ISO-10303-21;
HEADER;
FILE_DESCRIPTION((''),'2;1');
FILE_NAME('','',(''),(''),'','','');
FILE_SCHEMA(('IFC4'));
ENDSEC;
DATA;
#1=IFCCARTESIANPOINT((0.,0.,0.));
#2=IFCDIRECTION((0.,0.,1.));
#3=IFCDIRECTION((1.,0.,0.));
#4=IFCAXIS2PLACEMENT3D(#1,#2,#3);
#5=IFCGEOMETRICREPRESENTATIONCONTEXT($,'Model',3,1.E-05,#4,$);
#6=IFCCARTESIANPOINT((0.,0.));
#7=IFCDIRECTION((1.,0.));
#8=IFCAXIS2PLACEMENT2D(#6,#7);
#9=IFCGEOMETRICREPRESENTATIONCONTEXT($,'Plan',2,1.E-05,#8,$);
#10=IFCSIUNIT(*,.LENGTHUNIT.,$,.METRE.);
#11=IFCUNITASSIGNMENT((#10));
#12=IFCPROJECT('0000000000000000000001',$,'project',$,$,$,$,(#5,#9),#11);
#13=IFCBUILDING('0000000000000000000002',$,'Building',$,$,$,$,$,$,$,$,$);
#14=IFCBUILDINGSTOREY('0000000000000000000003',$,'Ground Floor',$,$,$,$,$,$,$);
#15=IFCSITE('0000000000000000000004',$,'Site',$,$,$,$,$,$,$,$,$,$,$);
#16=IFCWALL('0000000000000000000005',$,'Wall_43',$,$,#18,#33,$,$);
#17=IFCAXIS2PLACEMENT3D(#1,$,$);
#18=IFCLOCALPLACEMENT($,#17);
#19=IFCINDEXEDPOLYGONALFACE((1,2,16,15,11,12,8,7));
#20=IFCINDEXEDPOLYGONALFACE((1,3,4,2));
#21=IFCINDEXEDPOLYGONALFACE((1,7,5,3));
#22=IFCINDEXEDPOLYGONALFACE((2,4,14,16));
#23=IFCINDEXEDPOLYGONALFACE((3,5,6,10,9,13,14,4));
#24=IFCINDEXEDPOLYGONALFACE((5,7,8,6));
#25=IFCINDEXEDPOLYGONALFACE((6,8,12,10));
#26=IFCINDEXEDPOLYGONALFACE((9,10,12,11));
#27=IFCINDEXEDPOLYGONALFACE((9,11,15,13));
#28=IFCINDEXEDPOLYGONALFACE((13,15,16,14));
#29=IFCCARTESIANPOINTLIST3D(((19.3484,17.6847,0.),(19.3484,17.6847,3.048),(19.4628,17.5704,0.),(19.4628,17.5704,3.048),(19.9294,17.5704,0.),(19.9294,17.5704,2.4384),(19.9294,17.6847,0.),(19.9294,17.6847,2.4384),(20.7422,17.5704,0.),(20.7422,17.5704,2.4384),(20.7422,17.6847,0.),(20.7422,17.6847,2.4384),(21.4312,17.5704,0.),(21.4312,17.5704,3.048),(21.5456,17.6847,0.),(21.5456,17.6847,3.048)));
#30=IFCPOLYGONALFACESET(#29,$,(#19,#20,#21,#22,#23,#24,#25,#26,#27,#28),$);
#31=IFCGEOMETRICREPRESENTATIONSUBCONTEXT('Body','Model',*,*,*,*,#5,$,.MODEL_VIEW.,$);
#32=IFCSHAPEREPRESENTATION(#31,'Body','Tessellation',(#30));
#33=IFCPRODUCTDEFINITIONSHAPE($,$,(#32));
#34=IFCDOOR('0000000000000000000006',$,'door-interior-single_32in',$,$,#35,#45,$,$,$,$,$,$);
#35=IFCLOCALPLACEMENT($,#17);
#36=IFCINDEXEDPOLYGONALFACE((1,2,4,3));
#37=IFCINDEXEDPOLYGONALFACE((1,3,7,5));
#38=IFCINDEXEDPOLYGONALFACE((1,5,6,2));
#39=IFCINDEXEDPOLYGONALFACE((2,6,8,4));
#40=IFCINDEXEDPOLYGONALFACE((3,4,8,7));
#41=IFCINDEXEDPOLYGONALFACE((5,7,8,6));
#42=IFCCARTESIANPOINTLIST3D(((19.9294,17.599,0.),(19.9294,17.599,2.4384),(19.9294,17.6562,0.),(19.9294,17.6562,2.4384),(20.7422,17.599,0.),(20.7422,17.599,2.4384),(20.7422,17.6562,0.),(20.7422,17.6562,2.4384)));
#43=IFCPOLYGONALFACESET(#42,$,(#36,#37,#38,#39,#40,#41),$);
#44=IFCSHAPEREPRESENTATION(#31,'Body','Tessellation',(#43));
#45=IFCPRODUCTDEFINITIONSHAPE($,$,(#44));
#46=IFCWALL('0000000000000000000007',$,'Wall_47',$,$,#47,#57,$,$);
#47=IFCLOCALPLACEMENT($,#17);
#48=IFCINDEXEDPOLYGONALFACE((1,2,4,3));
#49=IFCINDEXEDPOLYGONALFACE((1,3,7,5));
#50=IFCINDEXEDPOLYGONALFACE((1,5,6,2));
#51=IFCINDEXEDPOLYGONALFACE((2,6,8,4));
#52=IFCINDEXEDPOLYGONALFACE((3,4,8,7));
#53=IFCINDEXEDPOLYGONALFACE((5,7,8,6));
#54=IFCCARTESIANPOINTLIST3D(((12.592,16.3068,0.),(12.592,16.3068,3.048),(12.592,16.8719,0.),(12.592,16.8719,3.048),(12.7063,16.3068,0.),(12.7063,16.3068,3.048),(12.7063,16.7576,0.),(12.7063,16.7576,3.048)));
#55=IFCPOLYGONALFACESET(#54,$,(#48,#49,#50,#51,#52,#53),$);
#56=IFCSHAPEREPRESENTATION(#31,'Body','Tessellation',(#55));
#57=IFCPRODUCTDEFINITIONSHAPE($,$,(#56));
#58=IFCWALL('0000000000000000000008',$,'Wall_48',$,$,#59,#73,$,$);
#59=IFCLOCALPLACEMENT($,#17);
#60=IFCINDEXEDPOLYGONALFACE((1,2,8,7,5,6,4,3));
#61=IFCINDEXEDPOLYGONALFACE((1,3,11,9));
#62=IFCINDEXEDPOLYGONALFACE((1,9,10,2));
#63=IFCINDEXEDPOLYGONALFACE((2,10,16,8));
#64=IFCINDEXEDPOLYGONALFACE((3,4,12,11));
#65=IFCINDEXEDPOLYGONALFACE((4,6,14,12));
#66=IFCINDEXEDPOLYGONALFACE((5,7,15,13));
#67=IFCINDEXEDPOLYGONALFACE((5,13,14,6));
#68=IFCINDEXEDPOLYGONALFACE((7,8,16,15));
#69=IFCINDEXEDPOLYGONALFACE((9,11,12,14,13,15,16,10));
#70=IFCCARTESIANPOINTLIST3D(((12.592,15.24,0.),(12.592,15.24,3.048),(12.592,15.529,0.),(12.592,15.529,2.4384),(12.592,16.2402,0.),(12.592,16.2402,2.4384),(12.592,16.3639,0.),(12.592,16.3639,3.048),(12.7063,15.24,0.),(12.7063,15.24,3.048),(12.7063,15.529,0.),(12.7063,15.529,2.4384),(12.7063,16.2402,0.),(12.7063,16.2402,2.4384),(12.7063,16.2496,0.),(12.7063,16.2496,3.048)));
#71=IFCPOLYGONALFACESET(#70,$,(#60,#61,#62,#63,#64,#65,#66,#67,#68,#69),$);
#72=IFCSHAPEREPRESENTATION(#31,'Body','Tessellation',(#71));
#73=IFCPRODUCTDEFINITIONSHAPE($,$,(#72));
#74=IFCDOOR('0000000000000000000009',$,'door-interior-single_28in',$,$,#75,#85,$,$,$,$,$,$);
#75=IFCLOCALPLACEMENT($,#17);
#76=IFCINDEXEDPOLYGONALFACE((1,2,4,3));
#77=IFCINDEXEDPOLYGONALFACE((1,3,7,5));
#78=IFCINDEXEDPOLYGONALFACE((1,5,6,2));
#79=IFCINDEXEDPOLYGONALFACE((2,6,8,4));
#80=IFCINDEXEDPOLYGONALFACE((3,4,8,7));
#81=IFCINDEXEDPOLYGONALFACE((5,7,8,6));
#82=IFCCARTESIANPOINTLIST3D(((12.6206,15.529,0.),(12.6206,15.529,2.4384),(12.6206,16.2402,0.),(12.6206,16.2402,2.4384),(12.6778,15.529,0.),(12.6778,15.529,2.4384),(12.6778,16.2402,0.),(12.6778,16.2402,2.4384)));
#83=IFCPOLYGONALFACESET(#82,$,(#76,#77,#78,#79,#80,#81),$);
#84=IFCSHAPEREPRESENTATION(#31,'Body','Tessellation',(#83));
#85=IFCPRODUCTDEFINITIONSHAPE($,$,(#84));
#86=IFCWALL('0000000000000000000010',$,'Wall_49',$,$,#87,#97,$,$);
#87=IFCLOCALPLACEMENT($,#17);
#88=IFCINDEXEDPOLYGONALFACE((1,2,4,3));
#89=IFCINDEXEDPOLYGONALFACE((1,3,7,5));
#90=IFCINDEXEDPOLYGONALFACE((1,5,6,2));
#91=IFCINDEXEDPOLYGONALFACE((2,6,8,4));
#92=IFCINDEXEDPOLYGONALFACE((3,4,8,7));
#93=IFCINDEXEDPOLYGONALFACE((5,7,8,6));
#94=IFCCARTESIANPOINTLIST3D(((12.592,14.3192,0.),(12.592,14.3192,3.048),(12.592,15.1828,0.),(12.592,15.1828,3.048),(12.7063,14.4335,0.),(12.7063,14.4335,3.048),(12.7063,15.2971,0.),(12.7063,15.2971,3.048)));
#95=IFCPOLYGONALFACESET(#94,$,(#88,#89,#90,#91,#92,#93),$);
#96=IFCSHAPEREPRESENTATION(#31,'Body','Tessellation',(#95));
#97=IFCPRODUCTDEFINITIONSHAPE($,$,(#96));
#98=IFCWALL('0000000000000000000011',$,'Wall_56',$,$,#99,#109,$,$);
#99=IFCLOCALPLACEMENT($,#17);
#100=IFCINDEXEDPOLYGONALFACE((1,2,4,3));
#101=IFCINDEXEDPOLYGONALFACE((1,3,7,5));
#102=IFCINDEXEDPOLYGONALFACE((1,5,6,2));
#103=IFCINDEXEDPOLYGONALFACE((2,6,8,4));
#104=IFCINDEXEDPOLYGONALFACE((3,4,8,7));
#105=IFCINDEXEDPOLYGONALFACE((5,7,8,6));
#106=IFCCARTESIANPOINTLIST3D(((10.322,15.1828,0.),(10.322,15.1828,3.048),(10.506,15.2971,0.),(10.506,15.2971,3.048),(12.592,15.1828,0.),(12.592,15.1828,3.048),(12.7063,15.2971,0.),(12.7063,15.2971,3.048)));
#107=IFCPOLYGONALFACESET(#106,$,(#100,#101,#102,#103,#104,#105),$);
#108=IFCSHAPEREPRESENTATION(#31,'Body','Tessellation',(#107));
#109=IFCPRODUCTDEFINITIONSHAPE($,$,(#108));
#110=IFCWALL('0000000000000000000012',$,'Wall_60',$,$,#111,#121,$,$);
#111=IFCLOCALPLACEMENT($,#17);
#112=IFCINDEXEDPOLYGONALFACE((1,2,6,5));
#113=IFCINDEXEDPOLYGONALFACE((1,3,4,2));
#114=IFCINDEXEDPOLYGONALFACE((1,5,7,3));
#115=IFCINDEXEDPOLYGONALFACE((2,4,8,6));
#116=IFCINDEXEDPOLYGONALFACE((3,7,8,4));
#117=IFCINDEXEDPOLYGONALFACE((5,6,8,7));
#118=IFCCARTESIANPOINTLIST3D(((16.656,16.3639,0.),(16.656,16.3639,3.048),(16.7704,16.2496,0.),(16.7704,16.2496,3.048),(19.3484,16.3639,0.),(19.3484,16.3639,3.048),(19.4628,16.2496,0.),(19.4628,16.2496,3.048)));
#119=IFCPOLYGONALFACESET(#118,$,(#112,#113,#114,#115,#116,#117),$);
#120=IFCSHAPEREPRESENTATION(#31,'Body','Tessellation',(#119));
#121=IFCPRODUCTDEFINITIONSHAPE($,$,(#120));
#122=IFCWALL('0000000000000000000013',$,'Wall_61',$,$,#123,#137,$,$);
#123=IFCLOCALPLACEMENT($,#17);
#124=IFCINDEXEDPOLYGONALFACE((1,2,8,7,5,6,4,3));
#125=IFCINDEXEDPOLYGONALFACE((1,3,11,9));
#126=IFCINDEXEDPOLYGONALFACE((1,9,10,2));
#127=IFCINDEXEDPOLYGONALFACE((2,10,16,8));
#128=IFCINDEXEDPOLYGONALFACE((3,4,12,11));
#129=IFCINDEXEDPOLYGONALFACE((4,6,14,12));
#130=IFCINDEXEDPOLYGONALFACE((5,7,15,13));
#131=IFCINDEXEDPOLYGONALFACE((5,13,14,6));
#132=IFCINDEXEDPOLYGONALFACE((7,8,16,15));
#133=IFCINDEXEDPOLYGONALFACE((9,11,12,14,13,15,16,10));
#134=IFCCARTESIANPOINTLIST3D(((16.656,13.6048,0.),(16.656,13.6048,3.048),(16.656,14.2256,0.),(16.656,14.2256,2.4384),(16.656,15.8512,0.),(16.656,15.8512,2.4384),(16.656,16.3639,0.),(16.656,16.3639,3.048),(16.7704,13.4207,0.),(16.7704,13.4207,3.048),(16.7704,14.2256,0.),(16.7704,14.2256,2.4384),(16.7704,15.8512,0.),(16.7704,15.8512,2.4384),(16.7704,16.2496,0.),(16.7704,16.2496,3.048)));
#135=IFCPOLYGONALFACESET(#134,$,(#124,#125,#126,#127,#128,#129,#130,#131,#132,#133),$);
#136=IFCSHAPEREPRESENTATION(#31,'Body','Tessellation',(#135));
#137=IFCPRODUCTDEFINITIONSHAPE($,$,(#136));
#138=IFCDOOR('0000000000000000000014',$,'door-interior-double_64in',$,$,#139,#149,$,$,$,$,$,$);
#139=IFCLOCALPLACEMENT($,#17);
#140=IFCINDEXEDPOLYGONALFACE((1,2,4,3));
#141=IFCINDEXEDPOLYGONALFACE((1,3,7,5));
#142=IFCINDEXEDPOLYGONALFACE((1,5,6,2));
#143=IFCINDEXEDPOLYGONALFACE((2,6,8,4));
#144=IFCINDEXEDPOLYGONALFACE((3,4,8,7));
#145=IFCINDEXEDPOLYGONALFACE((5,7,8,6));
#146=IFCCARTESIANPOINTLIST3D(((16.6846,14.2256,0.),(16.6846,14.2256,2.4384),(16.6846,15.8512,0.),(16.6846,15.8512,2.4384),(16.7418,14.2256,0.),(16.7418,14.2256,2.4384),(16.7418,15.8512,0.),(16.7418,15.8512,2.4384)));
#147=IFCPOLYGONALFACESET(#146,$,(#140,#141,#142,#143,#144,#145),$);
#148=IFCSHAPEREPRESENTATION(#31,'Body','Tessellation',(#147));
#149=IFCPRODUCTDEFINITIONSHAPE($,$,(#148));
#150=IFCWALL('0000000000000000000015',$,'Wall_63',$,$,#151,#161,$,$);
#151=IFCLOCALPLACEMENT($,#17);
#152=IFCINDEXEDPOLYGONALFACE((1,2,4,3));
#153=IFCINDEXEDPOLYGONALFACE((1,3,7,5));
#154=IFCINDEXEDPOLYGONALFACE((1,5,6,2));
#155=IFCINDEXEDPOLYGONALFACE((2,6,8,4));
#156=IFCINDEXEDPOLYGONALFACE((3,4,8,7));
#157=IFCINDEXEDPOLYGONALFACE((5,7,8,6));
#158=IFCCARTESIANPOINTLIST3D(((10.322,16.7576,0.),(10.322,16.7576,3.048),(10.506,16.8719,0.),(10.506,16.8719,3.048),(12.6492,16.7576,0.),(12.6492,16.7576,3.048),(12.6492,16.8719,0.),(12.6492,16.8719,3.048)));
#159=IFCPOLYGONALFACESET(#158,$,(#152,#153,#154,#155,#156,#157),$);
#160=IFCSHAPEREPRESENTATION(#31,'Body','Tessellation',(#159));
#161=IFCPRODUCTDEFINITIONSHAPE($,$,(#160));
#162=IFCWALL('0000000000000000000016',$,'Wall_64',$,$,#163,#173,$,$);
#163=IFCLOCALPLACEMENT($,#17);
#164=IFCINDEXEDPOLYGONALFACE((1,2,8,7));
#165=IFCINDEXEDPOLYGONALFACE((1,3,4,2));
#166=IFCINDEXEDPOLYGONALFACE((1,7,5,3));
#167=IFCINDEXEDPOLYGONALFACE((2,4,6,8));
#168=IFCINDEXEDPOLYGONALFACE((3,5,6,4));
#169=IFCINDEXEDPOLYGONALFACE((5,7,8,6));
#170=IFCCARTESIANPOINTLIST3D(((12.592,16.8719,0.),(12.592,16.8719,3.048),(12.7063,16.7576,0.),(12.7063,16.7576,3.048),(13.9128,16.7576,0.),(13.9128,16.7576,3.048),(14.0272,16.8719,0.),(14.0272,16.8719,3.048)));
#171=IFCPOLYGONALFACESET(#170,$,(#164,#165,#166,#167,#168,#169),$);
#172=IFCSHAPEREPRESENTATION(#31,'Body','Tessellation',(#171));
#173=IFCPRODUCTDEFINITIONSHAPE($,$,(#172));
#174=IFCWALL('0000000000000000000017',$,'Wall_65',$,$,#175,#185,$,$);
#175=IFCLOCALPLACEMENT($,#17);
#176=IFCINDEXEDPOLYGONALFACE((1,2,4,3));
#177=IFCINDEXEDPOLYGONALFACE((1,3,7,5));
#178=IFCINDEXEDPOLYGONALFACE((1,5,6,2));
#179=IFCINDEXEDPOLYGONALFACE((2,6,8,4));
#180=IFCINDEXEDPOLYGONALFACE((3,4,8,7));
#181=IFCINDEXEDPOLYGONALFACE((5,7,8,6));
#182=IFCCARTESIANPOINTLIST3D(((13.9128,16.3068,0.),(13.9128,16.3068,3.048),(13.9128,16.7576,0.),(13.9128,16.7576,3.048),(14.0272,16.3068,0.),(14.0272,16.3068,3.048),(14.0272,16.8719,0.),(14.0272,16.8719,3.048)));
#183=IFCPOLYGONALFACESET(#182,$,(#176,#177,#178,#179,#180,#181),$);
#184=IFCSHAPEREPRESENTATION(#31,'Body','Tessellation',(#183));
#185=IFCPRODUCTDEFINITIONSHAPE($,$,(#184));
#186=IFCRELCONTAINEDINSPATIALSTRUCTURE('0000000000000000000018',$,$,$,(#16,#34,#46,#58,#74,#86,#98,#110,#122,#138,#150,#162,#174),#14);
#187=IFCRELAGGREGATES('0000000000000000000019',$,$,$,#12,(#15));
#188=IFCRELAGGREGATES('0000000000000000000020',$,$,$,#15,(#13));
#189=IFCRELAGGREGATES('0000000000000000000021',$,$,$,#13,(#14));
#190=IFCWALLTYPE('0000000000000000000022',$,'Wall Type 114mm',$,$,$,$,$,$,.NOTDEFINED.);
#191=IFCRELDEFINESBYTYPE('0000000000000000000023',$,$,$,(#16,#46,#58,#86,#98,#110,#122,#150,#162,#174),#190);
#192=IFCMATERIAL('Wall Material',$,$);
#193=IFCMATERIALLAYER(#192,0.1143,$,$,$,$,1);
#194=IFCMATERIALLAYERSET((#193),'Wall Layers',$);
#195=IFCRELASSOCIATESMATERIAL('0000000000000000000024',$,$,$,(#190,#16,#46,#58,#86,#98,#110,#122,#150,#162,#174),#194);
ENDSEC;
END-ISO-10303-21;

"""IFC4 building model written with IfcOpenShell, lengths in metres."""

from ifc_helpers import new_model, si_unit, frame, origin_with_axes, origin_2d_with_axis, place, context, subcontext, project, spatial, line, indexed_curve, rectangle, outline, extrude, material, layer, layer_set, layer_usage, type_object, element, fill, save


model = new_model("IFC4")

# Units and contexts
model_context = context("Model", 3, precision=1e-05, world=origin_with_axes())
plan_context = context("Plan", 2, precision=1e-05, world=origin_2d_with_axis())
body_context = subcontext(model_context, "Body", "Model", "MODEL_VIEW")
ifc_project = project(units=[si_unit("LENGTHUNIT", "METRE")], contexts=[model_context, plan_context])

# Site, building, storey
site = spatial("IfcSite", under=ifc_project, Name="Site")
building = spatial("IfcBuilding", under=site, Name="Building")
storey = spatial("IfcBuildingStorey", under=building, Name="Ground Floor")

# Shared definitions
ifc_material_1 = material(Name="Wall Material")
ifc_layer_1 = layer(ifc_material_1, 0.1143, Priority=1)
ifc_layer_set_1 = layer_set([ifc_layer_1], Name="Wall Layers")
wall_type_1 = type_object("IfcWallType", Name="Wall Type 114mm", PredefinedType="NOTDEFINED", material=ifc_layer_set_1)

# Wall, opening, door
ifc_layer_usage_1 = layer_usage(ifc_layer_set_1, "AXIS2", "POSITIVE", -0.0571)
wall_1_placement = place(None, frame((19.4056, 17.6276, 0.0), z_axis=(0.0, 0.0, 1.0), x_axis=(1.0, 0.0, 0.0)))
wall_1 = element("IfcWall", 1, at=wall_1_placement, inside=storey, type_object=wall_type_1, material=ifc_layer_usage_1, Name="Wall_43", context=body_context, shape_type="SweptSolid", body=[
    extrude(outline(indexed_curve([(0.0571, -0.0571), (-0.0571, 0.0571), (2.1399, 0.0571), (2.0256, -0.0571)], segments=[line(1, 2, 3, 4, 1)])), origin_with_axes(), (0.0, 0.0, 1.0), 3.048),
])
opening_1_placement = place(wall_1_placement, frame((0.9302, 0.0, 0.0), z_axis=(0.0, 0.0, 1.0), x_axis=(1.0, 0.0, 0.0)))
opening_1 = element("IfcOpeningElement", 2, at=opening_1_placement, cuts=wall_1, context=body_context, shape_type="SweptSolid", body=[
    extrude(rectangle(XDim=0.8128, YDim=0.5), None, (0.0, 0.0, 1.0), 2.4384),
])
door_1_placement = place(None, frame((20.3358, 17.6276, 0.0), z_axis=(0.0, 0.0, 1.0), x_axis=(-1.0, 0.0, 0.0)))
door_1 = element("IfcDoor", 3, at=door_1_placement, inside=storey, Name="door-interior-single_32in", context=body_context, shape_type="SweptSolid", body=[
    extrude(rectangle(XDim=0.8128, YDim=0.0571), None, (0.0, 0.0, 1.0), 2.4384),
])
fill(opening_1, door_1)

# Wall
ifc_layer_usage_2 = layer_usage(ifc_layer_set_1, "AXIS2", "POSITIVE", -0.0571)
wall_2_placement = place(None, frame((12.6492, 16.8148, 0.0), z_axis=(0.0, 0.0, 1.0), x_axis=(0.0, -1.0, 0.0)))
element("IfcWall", 4, at=wall_2_placement, inside=storey, type_object=wall_type_1, material=ifc_layer_usage_2, Name="Wall_47", context=body_context, shape_type="SweptSolid", body=[
    extrude(outline(indexed_curve([(-0.0572, -0.0571), (0.0572, 0.0571), (0.508, 0.0571), (0.508, -0.0571)], segments=[line(1, 2, 3, 4, 1)])), origin_with_axes(), (0.0, 0.0, 1.0), 3.048),
])

# Wall, opening, door
ifc_layer_usage_3 = layer_usage(ifc_layer_set_1, "AXIS2", "POSITIVE", -0.0571)
wall_3_placement = place(None, frame((12.6492, 16.3068, 0.0), z_axis=(0.0, 0.0, 1.0), x_axis=(0.0, -1.0, 0.0)))
wall_3 = element("IfcWall", 5, at=wall_3_placement, inside=storey, type_object=wall_type_1, material=ifc_layer_usage_3, Name="Wall_48", context=body_context, shape_type="SweptSolid", body=[
    extrude(outline(indexed_curve([(-0.0572, -0.0571), (0.0572, 0.0571), (1.0668, 0.0571), (1.0668, -0.0571)], segments=[line(1, 2, 3, 4, 1)])), origin_with_axes(), (0.0, 0.0, 1.0), 3.048),
])
opening_2_placement = place(wall_3_placement, frame((0.4222, 0.0, 0.0), z_axis=(0.0, 0.0, 1.0), x_axis=(1.0, 0.0, 0.0)))
opening_2 = element("IfcOpeningElement", 6, at=opening_2_placement, cuts=wall_3, context=body_context, shape_type="SweptSolid", body=[
    extrude(rectangle(XDim=0.7112, YDim=0.5), None, (0.0, 0.0, 1.0), 2.4384),
])
door_2_placement = place(None, frame((12.6492, 15.8846, 0.0), z_axis=(0.0, 0.0, 1.0), x_axis=(0.0, 1.0, 0.0)))
door_2 = element("IfcDoor", 7, at=door_2_placement, inside=storey, Name="door-interior-single_28in", context=body_context, shape_type="SweptSolid", body=[
    extrude(rectangle(XDim=0.7112, YDim=0.0571), None, (0.0, 0.0, 1.0), 2.4384),
])
fill(opening_2, door_2)

# Walls
ifc_layer_usage_4 = layer_usage(ifc_layer_set_1, "AXIS2", "POSITIVE", -0.0571)
wall_4_placement = place(None, frame((12.6492, 15.24, 0.0), z_axis=(0.0, 0.0, 1.0), x_axis=(0.0, -1.0, 0.0)))
element("IfcWall", 8, at=wall_4_placement, inside=storey, type_object=wall_type_1, material=ifc_layer_usage_4, Name="Wall_49", context=body_context, shape_type="SweptSolid", body=[
    extrude(outline(indexed_curve([(0.0571, -0.0571), (-0.0571, 0.0571), (0.8064, 0.0571), (0.9207, -0.0571)], segments=[line(1, 2, 3, 4, 1)])), origin_with_axes(), (0.0, 0.0, 1.0), 3.048),
])
ifc_layer_usage_5 = layer_usage(ifc_layer_set_1, "AXIS2", "POSITIVE", -0.0571)
wall_5_placement = place(None, frame((12.6492, 15.24, 0.0), z_axis=(0.0, 0.0, 1.0), x_axis=(-1.0, 0.0, 0.0)))
element("IfcWall", 9, at=wall_5_placement, inside=storey, type_object=wall_type_1, material=ifc_layer_usage_5, Name="Wall_56", context=body_context, shape_type="SweptSolid", body=[
    extrude(outline(indexed_curve([(-0.0571, -0.0571), (0.0571, 0.0571), (2.3272, 0.0571), (2.1431, -0.0571)], segments=[line(1, 2, 3, 4, 1)])), origin_with_axes(), (0.0, 0.0, 1.0), 3.048),
])
ifc_layer_usage_6 = layer_usage(ifc_layer_set_1, "AXIS2", "POSITIVE", -0.0571)
wall_6_placement = place(None, frame((19.4056, 16.3068, 0.0), z_axis=(0.0, 0.0, 1.0), x_axis=(-1.0, 0.0, 0.0)))
element("IfcWall", 10, at=wall_6_placement, inside=storey, type_object=wall_type_1, material=ifc_layer_usage_6, Name="Wall_60", context=body_context, shape_type="SweptSolid", body=[
    extrude(outline(indexed_curve([(0.0572, -0.0571), (-0.0572, 0.0571), (2.6352, 0.0571), (2.7495, -0.0571)], segments=[line(1, 2, 3, 4, 1)])), origin_with_axes(), (0.0, 0.0, 1.0), 3.048),
])

# Wall, opening, door
ifc_layer_usage_7 = layer_usage(ifc_layer_set_1, "AXIS2", "POSITIVE", -0.0571)
wall_7_placement = place(None, frame((16.7132, 16.3068, 0.0), z_axis=(0.0, 0.0, 1.0), x_axis=(0.0, -1.0, 0.0)))
wall_7 = element("IfcWall", 11, at=wall_7_placement, inside=storey, type_object=wall_type_1, material=ifc_layer_usage_7, Name="Wall_61", context=body_context, shape_type="SweptSolid", body=[
    extrude(outline(indexed_curve([(-0.0572, -0.0571), (0.0572, 0.0571), (2.8861, 0.0571), (2.702, -0.0571)], segments=[line(1, 2, 3, 4, 1)])), origin_with_axes(), (0.0, 0.0, 1.0), 3.048),
])
opening_3_placement = place(wall_7_placement, frame((1.2684, 0.0, 0.0), z_axis=(0.0, 0.0, 1.0), x_axis=(1.0, 0.0, 0.0)))
opening_3 = element("IfcOpeningElement", 12, at=opening_3_placement, cuts=wall_7, context=body_context, shape_type="SweptSolid", body=[
    extrude(rectangle(XDim=1.6256, YDim=0.5), None, (0.0, 0.0, 1.0), 2.4384),
])
door_3_placement = place(None, frame((16.7132, 15.0384, 0.0), z_axis=(0.0, 0.0, 1.0), x_axis=(0.0, 1.0, 0.0)))
door_3 = element("IfcDoor", 13, at=door_3_placement, inside=storey, Name="door-interior-double_64in", context=body_context, shape_type="SweptSolid", body=[
    extrude(rectangle(XDim=1.6256, YDim=0.0571), None, (0.0, 0.0, 1.0), 2.4384),
])
fill(opening_3, door_3)

# Walls
ifc_layer_usage_8 = layer_usage(ifc_layer_set_1, "AXIS2", "POSITIVE", -0.0571)
wall_8_placement = place(None, frame((10.414, 16.8148, 0.0), z_axis=(0.0, 0.0, 1.0), x_axis=(1.0, 0.0, 0.0)))
element("IfcWall", 14, at=wall_8_placement, inside=storey, type_object=wall_type_1, material=ifc_layer_usage_8, Name="Wall_63", context=body_context, shape_type="SweptSolid", body=[
    extrude(outline(indexed_curve([(-0.0921, -0.0571), (0.0921, 0.0571), (2.2352, 0.0571), (2.2352, -0.0571)], segments=[line(1, 2, 3, 4, 1)])), origin_with_axes(), (0.0, 0.0, 1.0), 3.048),
])
ifc_layer_usage_9 = layer_usage(ifc_layer_set_1, "AXIS2", "POSITIVE", -0.0571)
wall_9_placement = place(None, frame((12.6492, 16.8148, 0.0), z_axis=(0.0, 0.0, 1.0), x_axis=(1.0, 0.0, 0.0)))
element("IfcWall", 15, at=wall_9_placement, inside=storey, type_object=wall_type_1, material=ifc_layer_usage_9, Name="Wall_64", context=body_context, shape_type="SweptSolid", body=[
    extrude(outline(indexed_curve([(0.0571, -0.0571), (-0.0571, 0.0571), (1.378, 0.0571), (1.2637, -0.0571)], segments=[line(1, 2, 3, 4, 1)])), origin_with_axes(), (0.0, 0.0, 1.0), 3.048),
])
ifc_layer_usage_10 = layer_usage(ifc_layer_set_1, "AXIS2", "POSITIVE", -0.0571)
wall_10_placement = place(None, frame((13.97, 16.8148, 0.0), z_axis=(0.0, 0.0, 1.0), x_axis=(0.0, -1.0, 0.0)))
element("IfcWall", 16, at=wall_10_placement, inside=storey, type_object=wall_type_1, material=ifc_layer_usage_10, Name="Wall_65", context=body_context, shape_type="SweptSolid", body=[
    extrude(outline(indexed_curve([(0.0571, -0.0571), (-0.0571, 0.0571), (0.508, 0.0571), (0.508, -0.0571)], segments=[line(1, 2, 3, 4, 1)])), origin_with_axes(), (0.0, 0.0, 1.0), 3.048),
])

save(model, "model.ifc")
